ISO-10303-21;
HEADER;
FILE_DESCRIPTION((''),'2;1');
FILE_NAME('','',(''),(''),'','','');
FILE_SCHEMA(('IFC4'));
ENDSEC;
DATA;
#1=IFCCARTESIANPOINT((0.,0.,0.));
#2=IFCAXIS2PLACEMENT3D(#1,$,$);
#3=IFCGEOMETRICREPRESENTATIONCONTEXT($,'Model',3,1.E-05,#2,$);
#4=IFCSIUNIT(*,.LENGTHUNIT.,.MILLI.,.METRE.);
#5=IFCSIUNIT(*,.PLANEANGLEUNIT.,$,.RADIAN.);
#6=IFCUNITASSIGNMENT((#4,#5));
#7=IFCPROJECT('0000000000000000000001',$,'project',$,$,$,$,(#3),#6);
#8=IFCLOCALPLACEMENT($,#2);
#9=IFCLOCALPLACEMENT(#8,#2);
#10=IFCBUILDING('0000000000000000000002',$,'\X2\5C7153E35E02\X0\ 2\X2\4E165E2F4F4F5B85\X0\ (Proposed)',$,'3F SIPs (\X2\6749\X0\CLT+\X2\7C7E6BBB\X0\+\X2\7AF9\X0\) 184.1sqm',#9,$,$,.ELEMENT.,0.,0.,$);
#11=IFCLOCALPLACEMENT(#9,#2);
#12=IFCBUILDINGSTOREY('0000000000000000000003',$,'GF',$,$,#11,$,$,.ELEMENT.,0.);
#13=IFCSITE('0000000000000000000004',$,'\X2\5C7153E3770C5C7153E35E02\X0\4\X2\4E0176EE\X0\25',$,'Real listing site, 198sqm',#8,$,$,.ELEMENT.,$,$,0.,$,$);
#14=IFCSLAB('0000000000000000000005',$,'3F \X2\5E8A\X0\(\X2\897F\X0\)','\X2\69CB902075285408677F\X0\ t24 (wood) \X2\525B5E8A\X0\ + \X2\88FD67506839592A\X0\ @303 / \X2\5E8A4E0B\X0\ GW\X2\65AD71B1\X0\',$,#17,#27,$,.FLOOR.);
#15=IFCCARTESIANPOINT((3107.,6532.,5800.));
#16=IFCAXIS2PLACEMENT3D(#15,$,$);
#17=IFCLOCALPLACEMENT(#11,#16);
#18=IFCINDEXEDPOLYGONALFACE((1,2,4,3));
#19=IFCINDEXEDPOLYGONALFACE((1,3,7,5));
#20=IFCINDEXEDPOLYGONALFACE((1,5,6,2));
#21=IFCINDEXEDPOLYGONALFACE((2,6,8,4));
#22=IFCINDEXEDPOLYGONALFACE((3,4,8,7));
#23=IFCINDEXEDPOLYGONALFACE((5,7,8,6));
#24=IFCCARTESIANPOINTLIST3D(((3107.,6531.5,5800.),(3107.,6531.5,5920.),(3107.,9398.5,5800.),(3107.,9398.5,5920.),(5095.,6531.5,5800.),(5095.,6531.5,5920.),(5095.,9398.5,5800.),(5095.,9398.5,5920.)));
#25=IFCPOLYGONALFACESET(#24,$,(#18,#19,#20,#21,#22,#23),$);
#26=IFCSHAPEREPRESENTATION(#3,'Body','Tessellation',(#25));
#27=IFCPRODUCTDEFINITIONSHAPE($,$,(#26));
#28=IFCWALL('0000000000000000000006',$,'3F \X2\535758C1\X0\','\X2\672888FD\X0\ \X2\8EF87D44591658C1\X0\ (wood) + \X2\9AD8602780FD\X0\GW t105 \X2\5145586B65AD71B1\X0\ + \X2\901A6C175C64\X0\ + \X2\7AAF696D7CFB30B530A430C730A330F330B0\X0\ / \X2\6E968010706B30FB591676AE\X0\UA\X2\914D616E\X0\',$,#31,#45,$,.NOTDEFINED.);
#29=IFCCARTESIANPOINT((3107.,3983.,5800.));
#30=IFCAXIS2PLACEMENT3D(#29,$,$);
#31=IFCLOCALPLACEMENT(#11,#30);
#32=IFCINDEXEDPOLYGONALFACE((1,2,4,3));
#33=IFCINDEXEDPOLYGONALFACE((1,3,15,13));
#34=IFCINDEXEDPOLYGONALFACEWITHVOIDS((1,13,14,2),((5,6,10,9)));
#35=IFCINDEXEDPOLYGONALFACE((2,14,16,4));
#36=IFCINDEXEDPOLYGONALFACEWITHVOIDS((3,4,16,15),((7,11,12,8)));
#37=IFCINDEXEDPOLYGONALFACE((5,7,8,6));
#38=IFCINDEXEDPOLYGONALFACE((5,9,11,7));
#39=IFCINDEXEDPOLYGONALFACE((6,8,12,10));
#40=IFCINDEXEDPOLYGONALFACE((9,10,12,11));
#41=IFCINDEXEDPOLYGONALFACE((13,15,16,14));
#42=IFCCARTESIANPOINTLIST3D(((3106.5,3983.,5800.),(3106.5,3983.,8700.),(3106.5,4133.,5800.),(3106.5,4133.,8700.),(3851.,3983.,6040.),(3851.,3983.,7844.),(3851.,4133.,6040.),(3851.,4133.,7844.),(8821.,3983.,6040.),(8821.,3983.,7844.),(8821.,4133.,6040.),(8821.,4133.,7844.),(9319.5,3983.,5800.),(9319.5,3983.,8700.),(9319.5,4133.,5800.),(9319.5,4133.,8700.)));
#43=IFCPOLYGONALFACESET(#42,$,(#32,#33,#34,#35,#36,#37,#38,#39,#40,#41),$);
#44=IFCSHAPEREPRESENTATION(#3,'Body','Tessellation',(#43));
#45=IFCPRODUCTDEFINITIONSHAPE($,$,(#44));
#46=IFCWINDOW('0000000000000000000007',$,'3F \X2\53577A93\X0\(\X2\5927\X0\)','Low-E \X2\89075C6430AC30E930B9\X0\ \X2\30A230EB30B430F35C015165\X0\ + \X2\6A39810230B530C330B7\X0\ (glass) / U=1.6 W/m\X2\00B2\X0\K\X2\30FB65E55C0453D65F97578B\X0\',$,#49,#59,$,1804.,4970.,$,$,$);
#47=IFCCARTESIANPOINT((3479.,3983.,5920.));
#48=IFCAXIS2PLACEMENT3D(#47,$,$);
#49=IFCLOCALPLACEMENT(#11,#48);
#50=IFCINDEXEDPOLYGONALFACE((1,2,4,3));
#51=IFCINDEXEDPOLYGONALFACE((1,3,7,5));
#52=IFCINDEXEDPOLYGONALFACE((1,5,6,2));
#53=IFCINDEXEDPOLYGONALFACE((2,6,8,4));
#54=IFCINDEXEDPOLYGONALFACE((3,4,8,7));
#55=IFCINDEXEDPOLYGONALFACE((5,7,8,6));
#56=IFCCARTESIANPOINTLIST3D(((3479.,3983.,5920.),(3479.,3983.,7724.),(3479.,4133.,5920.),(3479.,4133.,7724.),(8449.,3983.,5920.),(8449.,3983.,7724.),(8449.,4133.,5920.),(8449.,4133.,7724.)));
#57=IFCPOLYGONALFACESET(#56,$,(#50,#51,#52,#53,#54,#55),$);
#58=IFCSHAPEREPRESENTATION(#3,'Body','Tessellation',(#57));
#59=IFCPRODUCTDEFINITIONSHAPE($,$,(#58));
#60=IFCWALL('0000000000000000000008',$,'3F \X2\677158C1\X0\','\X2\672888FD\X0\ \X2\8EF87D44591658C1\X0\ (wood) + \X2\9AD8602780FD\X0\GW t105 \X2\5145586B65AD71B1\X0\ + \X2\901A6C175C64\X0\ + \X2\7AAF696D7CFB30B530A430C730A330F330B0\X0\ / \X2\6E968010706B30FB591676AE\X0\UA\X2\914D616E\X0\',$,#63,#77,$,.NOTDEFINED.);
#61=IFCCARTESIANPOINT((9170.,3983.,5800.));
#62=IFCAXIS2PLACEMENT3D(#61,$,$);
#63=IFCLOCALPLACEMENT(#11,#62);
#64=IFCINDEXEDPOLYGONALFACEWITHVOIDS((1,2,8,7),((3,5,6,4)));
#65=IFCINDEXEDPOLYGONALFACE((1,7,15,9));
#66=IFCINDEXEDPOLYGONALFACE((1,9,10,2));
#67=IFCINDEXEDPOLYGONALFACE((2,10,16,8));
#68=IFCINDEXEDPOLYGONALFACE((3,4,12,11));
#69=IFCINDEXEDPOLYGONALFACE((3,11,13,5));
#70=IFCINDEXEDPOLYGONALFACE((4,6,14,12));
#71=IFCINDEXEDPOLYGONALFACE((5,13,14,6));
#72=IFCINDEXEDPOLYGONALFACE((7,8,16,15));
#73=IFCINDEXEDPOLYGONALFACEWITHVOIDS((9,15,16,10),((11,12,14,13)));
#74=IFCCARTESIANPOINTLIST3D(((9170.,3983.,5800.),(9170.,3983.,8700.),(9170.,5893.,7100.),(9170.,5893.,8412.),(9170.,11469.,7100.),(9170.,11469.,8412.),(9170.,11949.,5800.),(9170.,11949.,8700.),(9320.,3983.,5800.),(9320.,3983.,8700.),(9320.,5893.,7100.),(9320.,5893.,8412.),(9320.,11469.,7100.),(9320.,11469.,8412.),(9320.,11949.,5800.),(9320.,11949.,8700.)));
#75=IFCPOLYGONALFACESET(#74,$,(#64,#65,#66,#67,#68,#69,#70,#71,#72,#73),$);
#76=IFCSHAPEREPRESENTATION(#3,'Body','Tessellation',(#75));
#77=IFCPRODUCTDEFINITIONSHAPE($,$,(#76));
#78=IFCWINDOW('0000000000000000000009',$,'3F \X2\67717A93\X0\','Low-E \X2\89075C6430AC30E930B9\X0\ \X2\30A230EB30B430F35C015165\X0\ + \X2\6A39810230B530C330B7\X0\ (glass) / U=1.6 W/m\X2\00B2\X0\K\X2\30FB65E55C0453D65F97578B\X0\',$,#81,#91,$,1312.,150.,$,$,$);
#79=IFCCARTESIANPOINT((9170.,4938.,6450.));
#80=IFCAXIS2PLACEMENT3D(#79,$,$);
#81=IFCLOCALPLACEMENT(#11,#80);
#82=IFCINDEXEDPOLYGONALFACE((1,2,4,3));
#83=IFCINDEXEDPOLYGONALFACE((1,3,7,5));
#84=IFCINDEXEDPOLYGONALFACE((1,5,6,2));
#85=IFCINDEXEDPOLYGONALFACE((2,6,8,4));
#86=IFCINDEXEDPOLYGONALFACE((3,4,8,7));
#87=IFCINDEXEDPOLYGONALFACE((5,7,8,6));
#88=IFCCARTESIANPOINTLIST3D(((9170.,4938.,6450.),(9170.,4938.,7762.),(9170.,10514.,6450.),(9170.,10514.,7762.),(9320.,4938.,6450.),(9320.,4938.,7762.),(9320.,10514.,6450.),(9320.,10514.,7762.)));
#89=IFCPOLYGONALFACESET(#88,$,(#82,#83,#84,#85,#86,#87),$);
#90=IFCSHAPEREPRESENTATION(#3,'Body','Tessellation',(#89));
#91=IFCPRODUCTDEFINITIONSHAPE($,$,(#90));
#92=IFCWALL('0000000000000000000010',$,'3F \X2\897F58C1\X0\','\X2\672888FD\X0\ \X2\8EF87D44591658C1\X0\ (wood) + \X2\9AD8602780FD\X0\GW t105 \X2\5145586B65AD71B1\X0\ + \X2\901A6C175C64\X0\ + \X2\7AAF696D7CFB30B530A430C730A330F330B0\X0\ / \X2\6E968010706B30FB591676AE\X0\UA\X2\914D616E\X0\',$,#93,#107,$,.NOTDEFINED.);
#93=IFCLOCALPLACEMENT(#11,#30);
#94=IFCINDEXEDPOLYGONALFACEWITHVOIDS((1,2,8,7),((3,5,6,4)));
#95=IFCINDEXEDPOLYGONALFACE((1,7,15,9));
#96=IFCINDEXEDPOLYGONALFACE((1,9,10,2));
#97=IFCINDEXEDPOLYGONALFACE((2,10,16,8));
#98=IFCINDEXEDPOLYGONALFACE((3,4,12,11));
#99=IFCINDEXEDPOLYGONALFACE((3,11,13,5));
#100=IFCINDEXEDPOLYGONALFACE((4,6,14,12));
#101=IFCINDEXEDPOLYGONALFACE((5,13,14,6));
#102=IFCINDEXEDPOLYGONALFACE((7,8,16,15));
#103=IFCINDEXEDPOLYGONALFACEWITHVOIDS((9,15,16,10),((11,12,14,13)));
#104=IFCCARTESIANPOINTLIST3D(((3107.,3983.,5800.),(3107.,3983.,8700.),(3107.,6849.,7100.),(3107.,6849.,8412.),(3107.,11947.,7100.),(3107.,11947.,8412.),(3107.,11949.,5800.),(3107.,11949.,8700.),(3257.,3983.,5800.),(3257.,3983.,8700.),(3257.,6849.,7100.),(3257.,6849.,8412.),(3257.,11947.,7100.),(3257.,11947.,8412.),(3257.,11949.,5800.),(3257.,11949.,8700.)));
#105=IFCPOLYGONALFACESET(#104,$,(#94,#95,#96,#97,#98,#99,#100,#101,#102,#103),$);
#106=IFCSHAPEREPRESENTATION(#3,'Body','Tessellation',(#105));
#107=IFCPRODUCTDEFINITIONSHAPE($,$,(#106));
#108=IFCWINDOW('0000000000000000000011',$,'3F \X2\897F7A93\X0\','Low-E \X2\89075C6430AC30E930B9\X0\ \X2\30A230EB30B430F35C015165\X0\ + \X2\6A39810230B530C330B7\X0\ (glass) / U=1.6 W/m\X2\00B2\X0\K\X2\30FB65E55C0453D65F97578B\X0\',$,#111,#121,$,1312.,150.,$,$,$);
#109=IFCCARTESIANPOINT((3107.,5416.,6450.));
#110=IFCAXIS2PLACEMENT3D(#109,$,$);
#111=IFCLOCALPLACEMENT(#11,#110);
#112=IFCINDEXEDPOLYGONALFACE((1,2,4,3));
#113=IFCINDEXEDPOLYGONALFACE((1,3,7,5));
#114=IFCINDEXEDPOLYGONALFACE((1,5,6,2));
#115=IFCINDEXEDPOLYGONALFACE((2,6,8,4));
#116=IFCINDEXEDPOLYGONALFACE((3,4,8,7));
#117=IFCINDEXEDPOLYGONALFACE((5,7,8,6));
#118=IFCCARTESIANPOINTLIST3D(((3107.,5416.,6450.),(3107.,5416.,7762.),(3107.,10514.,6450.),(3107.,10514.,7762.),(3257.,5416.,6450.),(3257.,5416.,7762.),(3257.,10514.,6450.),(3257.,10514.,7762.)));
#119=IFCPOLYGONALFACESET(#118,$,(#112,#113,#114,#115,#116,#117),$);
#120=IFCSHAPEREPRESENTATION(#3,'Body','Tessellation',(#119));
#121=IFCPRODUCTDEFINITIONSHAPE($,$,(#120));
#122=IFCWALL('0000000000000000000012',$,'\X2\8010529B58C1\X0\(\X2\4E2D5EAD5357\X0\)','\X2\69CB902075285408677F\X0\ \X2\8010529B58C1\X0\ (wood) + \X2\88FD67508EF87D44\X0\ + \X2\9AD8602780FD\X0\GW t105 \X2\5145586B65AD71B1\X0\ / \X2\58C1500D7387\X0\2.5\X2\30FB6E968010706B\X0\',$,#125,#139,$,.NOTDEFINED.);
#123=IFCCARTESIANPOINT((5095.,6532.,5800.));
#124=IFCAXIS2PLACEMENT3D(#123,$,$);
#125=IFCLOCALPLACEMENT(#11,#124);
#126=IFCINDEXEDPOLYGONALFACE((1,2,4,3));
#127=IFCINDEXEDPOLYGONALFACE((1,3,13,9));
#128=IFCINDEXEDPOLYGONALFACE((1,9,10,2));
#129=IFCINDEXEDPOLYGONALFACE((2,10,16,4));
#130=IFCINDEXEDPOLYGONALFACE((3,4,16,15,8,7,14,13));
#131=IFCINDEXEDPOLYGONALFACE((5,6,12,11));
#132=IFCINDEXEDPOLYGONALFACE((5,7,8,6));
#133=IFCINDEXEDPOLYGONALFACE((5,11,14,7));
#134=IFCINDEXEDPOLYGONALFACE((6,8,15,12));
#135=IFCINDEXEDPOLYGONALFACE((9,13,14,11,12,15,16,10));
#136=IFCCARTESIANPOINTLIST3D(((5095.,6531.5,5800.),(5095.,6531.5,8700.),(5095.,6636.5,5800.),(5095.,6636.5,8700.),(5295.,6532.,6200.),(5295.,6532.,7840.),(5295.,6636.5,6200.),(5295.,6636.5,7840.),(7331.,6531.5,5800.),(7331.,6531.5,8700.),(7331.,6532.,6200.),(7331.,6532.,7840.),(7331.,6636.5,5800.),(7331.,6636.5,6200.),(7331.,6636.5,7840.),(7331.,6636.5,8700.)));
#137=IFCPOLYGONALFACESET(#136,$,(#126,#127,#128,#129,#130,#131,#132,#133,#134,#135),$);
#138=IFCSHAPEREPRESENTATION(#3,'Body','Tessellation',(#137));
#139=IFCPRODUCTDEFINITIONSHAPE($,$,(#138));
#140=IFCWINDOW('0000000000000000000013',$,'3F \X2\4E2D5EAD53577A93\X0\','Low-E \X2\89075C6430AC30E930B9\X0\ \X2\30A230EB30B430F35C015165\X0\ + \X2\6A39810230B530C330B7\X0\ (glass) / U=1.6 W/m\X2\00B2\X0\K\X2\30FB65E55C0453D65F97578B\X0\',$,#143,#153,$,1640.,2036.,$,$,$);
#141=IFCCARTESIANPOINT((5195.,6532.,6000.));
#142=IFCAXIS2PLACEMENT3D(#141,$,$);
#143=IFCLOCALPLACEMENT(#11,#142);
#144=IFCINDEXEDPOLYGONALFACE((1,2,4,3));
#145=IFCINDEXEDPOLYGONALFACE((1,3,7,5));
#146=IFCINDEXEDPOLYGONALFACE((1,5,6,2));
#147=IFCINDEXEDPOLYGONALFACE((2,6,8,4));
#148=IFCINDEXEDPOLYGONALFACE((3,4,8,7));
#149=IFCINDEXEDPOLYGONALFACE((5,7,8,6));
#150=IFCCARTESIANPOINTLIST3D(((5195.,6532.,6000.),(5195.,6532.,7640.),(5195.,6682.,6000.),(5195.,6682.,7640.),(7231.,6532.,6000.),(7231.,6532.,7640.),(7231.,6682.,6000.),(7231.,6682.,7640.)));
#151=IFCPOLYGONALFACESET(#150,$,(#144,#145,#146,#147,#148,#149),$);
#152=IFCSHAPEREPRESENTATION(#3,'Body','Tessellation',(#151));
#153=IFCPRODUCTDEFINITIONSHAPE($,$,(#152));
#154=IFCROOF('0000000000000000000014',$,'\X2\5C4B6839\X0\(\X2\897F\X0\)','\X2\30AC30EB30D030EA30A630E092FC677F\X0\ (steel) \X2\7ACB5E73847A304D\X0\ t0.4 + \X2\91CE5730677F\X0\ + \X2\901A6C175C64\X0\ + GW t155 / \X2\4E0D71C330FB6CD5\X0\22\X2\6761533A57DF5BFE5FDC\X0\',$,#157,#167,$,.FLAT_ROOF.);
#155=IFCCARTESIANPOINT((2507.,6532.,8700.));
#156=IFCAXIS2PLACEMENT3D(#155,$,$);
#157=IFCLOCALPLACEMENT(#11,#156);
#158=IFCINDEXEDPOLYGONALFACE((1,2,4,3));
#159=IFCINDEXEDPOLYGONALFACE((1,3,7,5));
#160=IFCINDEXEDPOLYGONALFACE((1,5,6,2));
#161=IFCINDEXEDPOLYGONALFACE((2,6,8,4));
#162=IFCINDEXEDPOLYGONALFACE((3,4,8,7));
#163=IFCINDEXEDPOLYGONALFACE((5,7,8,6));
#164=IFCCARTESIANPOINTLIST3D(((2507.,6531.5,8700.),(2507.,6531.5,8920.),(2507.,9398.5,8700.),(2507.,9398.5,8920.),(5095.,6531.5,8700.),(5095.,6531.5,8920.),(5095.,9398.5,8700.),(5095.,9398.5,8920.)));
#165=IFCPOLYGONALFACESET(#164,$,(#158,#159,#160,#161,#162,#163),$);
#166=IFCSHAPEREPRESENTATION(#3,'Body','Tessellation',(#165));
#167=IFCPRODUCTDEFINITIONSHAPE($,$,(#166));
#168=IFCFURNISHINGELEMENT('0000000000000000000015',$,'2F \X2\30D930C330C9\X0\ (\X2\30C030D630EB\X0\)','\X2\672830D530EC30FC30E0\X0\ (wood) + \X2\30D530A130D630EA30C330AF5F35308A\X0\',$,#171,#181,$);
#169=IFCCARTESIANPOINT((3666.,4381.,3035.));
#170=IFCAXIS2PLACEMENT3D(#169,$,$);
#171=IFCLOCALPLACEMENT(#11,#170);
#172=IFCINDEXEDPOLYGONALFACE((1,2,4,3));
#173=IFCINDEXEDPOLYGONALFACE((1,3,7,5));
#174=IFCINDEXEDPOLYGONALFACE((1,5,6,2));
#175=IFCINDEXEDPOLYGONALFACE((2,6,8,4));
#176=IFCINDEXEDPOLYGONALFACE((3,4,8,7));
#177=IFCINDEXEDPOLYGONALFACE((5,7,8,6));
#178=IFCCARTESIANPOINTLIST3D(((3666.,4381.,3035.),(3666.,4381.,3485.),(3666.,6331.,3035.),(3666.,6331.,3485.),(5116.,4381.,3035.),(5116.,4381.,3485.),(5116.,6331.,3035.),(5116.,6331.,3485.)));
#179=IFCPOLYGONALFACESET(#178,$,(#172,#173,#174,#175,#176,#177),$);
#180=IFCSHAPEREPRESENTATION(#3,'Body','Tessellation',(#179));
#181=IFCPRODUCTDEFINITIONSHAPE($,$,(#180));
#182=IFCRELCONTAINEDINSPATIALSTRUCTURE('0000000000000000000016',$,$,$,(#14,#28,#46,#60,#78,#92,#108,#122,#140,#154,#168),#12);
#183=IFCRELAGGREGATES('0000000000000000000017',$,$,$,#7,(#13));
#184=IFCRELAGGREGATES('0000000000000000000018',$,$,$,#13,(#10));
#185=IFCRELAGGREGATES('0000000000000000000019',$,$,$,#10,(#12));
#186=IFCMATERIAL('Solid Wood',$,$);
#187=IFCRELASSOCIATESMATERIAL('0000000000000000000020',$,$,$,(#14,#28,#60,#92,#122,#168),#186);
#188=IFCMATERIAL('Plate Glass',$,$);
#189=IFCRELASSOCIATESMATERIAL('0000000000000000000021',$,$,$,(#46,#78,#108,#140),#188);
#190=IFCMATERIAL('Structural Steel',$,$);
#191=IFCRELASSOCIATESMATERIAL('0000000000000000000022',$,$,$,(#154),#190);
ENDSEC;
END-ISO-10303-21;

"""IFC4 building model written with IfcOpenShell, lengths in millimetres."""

from ifc_helpers import new_model, si_unit, frame, frame_2d, origin, place, context, project, spatial, rectangle, extrude, material, element, fill, save


model = new_model("IFC4")

# Units and contexts
model_context = context("Model", 3, precision=1e-05, world=origin())
ifc_project = project(units=[si_unit("LENGTHUNIT", "METRE", prefix="MILLI"), si_unit("PLANEANGLEUNIT", "RADIAN")], contexts=[model_context])

# Site, building, storey
site_placement = place(None, origin())
site = spatial("IfcSite", under=ifc_project, at=site_placement, Name="山口県山口市4丁目25", ObjectType="Real listing site, 198sqm", CompositionType="ELEMENT", RefElevation=0.0)
building_placement = place(site_placement, origin())
building = spatial("IfcBuilding", under=site, at=building_placement, Name="山口市 2世帯住宅 (Proposed)", ObjectType="3F SIPs (杉CLT+籾殻+竹) 184.1sqm", CompositionType="ELEMENT", ElevationOfRefHeight=0.0, ElevationOfTerrain=0.0)
storey_placement = place(building_placement, origin())
storey = spatial("IfcBuildingStorey", under=building, at=storey_placement, Name="GF", CompositionType="ELEMENT", Elevation=0.0)

# Slab
ifc_material_1 = material(Name="Solid Wood")
slab_1_placement = place(storey_placement, frame((3107.0, 6532.0, 5800.0)))
element("IfcSlab", 1, at=slab_1_placement, inside=storey, material=ifc_material_1, Name="3F 床(西)", Description="構造用合板 t24 (wood) 剛床 + 製材根太 @303 / 床下 GW断熱", PredefinedType="FLOOR", context=model_context, shape_type="SweptSolid", body=[
    extrude(rectangle(XDim=1988.0, YDim=2867.0, at=frame_2d((994.0, 1433.0))), frame((3107.0, 6532.0, 5800.0)), (0.0, 0.0, 1.0), 120.0),
])

# Walls, openings, windows
wall_1_placement = place(storey_placement, frame((3107.0, 3983.0, 5800.0)))
wall_1 = element("IfcWall", 2, at=wall_1_placement, inside=storey, material=ifc_material_1, Name="3F 南壁", Description="木製 軸組外壁 (wood) + 高性能GW t105 充填断熱 + 通気層 + 窯業系サイディング / 準耐火・外皮UA配慮", PredefinedType="NOTDEFINED", context=model_context, shape_type="SweptSolid", body=[
    extrude(rectangle(XDim=6213.0, YDim=150.0, at=frame_2d((3106.0, 75.0))), frame((3107.0, 3983.0, 5800.0)), (0.0, 0.0, 1.0), 2900.0),
])
opening_1_placement = place(storey_placement, frame((3479.0, 3983.0, 5920.0)))
opening_1 = element("IfcOpeningElement", 3, at=opening_1_placement, cuts=wall_1, PredefinedType="NOTDEFINED", context=model_context, shape_type="SweptSolid", body=[
    extrude(rectangle(XDim=4970.0, YDim=150.0, at=frame_2d((2485.0, 75.0))), frame((3479.0, 3983.0, 5920.0)), (0.0, 0.0, 1.0), 1804.0),
])
ifc_material_2 = material(Name="Plate Glass")
window_1_placement = place(storey_placement, frame((3479.0, 3983.0, 5920.0)))
window_1 = element("IfcWindow", 4, at=window_1_placement, inside=storey, material=ifc_material_2, Name="3F 南窓(大)", Description="Low-E 複層ガラス アルゴン封入 + 樹脂サッシ (glass) / U=1.6 W/m²K・日射取得型", OverallHeight=1804.0, OverallWidth=4970.0, context=model_context, shape_type="SweptSolid", body=[
    extrude(rectangle(XDim=4970.0, YDim=150.0, at=frame_2d((2485.0, 75.0))), frame((3479.0, 3983.0, 5920.0)), (0.0, 0.0, 1.0), 1804.0),
])
fill(opening_1, window_1)
wall_2_placement = place(storey_placement, frame((9170.0, 3983.0, 5800.0)))
wall_2 = element("IfcWall", 5, at=wall_2_placement, inside=storey, material=ifc_material_1, Name="3F 東壁", Description="木製 軸組外壁 (wood) + 高性能GW t105 充填断熱 + 通気層 + 窯業系サイディング / 準耐火・外皮UA配慮", PredefinedType="NOTDEFINED", context=model_context, shape_type="SweptSolid", body=[
    extrude(rectangle(XDim=150.0, YDim=7966.0, at=frame_2d((75.0, 3983.0))), frame((9170.0, 3983.0, 5800.0)), (0.0, 0.0, 1.0), 2900.0),
])
opening_2_placement = place(storey_placement, frame((9170.0, 4938.0, 6450.0)))
opening_2 = element("IfcOpeningElement", 6, at=opening_2_placement, cuts=wall_2, PredefinedType="NOTDEFINED", context=model_context, shape_type="SweptSolid", body=[
    extrude(rectangle(XDim=150.0, YDim=5576.0, at=frame_2d((75.0, 2788.0))), frame((9170.0, 4938.0, 6450.0)), (0.0, 0.0, 1.0), 1312.0),
])
window_2_placement = place(storey_placement, frame((9170.0, 4938.0, 6450.0)))
window_2 = element("IfcWindow", 7, at=window_2_placement, inside=storey, material=ifc_material_2, Name="3F 東窓", Description="Low-E 複層ガラス アルゴン封入 + 樹脂サッシ (glass) / U=1.6 W/m²K・日射取得型", OverallHeight=1312.0, OverallWidth=150.0, context=model_context, shape_type="SweptSolid", body=[
    extrude(rectangle(XDim=150.0, YDim=5576.0, at=frame_2d((75.0, 2788.0))), frame((9170.0, 4938.0, 6450.0)), (0.0, 0.0, 1.0), 1312.0),
])
fill(opening_2, window_2)
wall_3_placement = place(storey_placement, frame((3107.0, 3983.0, 5800.0)))
wall_3 = element("IfcWall", 8, at=wall_3_placement, inside=storey, material=ifc_material_1, Name="3F 西壁", Description="木製 軸組外壁 (wood) + 高性能GW t105 充填断熱 + 通気層 + 窯業系サイディング / 準耐火・外皮UA配慮", PredefinedType="NOTDEFINED", context=model_context, shape_type="SweptSolid", body=[
    extrude(rectangle(XDim=150.0, YDim=7966.0, at=frame_2d((75.0, 3983.0))), frame((3107.0, 3983.0, 5800.0)), (0.0, 0.0, 1.0), 2900.0),
])
opening_3_placement = place(storey_placement, frame((3107.0, 5416.0, 6450.0)))
opening_3 = element("IfcOpeningElement", 9, at=opening_3_placement, cuts=wall_3, PredefinedType="NOTDEFINED", context=model_context, shape_type="SweptSolid", body=[
    extrude(rectangle(XDim=150.0, YDim=5098.0, at=frame_2d((75.0, 2549.0))), frame((3107.0, 5416.0, 6450.0)), (0.0, 0.0, 1.0), 1312.0),
])
window_3_placement = place(storey_placement, frame((3107.0, 5416.0, 6450.0)))
window_3 = element("IfcWindow", 10, at=window_3_placement, inside=storey, material=ifc_material_2, Name="3F 西窓", Description="Low-E 複層ガラス アルゴン封入 + 樹脂サッシ (glass) / U=1.6 W/m²K・日射取得型", OverallHeight=1312.0, OverallWidth=150.0, context=model_context, shape_type="SweptSolid", body=[
    extrude(rectangle(XDim=150.0, YDim=5098.0, at=frame_2d((75.0, 2549.0))), frame((3107.0, 5416.0, 6450.0)), (0.0, 0.0, 1.0), 1312.0),
])
fill(opening_3, window_3)
wall_4_placement = place(storey_placement, frame((5095.0, 6532.0, 5800.0)))
wall_4 = element("IfcWall", 11, at=wall_4_placement, inside=storey, material=ifc_material_1, Name="耐力壁(中庭南)", Description="構造用合板 耐力壁 (wood) + 製材軸組 + 高性能GW t105 充填断熱 / 壁倍率2.5・準耐火", PredefinedType="NOTDEFINED", context=model_context, shape_type="SweptSolid", body=[
    extrude(rectangle(XDim=2236.0, YDim=105.0, at=frame_2d((1118.0, 52.0))), frame((5095.0, 6532.0, 5800.0)), (0.0, 0.0, 1.0), 2900.0),
])
opening_4_placement = place(storey_placement, frame((5195.0, 6532.0, 6000.0)))
opening_4 = element("IfcOpeningElement", 12, at=opening_4_placement, cuts=wall_4, PredefinedType="NOTDEFINED", context=model_context, shape_type="SweptSolid", body=[
    extrude(rectangle(XDim=2036.0, YDim=150.0, at=frame_2d((1018.0, 75.0))), frame((5195.0, 6532.0, 6000.0)), (0.0, 0.0, 1.0), 1640.0),
])
window_4_placement = place(storey_placement, frame((5195.0, 6532.0, 6000.0)))
window_4 = element("IfcWindow", 13, at=window_4_placement, inside=storey, material=ifc_material_2, Name="3F 中庭南窓", Description="Low-E 複層ガラス アルゴン封入 + 樹脂サッシ (glass) / U=1.6 W/m²K・日射取得型", OverallHeight=1640.0, OverallWidth=2036.0, context=model_context, shape_type="SweptSolid", body=[
    extrude(rectangle(XDim=2036.0, YDim=150.0, at=frame_2d((1018.0, 75.0))), frame((5195.0, 6532.0, 6000.0)), (0.0, 0.0, 1.0), 1640.0),
])
fill(opening_4, window_4)

# Roof
ifc_material_3 = material(Name="Structural Steel")
roof_1_placement = place(storey_placement, frame((2507.0, 6532.0, 8700.0)))
element("IfcRoof", 14, at=roof_1_placement, inside=storey, material=ifc_material_3, Name="屋根(西)", Description="ガルバリウム鋼板 (steel) 立平葺き t0.4 + 野地板 + 通気層 + GW t155 / 不燃・法22条区域対応", PredefinedType="FLAT_ROOF", context=model_context, shape_type="SweptSolid", body=[
    extrude(rectangle(XDim=2588.0, YDim=2867.0, at=frame_2d((1294.0, 1433.0))), frame((2507.0, 6532.0, 8700.0)), (0.0, 0.0, 1.0), 220.0),
])

# Furnishing element
furnishing_1_placement = place(storey_placement, frame((3666.0, 4381.0, 3035.0)))
element("IfcFurnishingElement", 15, at=furnishing_1_placement, inside=storey, material=ifc_material_1, Name="2F ベッド (ダブル)", Description="木フレーム (wood) + ファブリック張り", context=model_context, shape_type="SweptSolid", body=[
    extrude(rectangle(XDim=1450.0, YDim=1950.0, at=frame_2d((725.0, 975.0))), frame((3666.0, 4381.0, 3035.0)), (0.0, 0.0, 1.0), 450.0),
])

save(model, "model.ifc")
